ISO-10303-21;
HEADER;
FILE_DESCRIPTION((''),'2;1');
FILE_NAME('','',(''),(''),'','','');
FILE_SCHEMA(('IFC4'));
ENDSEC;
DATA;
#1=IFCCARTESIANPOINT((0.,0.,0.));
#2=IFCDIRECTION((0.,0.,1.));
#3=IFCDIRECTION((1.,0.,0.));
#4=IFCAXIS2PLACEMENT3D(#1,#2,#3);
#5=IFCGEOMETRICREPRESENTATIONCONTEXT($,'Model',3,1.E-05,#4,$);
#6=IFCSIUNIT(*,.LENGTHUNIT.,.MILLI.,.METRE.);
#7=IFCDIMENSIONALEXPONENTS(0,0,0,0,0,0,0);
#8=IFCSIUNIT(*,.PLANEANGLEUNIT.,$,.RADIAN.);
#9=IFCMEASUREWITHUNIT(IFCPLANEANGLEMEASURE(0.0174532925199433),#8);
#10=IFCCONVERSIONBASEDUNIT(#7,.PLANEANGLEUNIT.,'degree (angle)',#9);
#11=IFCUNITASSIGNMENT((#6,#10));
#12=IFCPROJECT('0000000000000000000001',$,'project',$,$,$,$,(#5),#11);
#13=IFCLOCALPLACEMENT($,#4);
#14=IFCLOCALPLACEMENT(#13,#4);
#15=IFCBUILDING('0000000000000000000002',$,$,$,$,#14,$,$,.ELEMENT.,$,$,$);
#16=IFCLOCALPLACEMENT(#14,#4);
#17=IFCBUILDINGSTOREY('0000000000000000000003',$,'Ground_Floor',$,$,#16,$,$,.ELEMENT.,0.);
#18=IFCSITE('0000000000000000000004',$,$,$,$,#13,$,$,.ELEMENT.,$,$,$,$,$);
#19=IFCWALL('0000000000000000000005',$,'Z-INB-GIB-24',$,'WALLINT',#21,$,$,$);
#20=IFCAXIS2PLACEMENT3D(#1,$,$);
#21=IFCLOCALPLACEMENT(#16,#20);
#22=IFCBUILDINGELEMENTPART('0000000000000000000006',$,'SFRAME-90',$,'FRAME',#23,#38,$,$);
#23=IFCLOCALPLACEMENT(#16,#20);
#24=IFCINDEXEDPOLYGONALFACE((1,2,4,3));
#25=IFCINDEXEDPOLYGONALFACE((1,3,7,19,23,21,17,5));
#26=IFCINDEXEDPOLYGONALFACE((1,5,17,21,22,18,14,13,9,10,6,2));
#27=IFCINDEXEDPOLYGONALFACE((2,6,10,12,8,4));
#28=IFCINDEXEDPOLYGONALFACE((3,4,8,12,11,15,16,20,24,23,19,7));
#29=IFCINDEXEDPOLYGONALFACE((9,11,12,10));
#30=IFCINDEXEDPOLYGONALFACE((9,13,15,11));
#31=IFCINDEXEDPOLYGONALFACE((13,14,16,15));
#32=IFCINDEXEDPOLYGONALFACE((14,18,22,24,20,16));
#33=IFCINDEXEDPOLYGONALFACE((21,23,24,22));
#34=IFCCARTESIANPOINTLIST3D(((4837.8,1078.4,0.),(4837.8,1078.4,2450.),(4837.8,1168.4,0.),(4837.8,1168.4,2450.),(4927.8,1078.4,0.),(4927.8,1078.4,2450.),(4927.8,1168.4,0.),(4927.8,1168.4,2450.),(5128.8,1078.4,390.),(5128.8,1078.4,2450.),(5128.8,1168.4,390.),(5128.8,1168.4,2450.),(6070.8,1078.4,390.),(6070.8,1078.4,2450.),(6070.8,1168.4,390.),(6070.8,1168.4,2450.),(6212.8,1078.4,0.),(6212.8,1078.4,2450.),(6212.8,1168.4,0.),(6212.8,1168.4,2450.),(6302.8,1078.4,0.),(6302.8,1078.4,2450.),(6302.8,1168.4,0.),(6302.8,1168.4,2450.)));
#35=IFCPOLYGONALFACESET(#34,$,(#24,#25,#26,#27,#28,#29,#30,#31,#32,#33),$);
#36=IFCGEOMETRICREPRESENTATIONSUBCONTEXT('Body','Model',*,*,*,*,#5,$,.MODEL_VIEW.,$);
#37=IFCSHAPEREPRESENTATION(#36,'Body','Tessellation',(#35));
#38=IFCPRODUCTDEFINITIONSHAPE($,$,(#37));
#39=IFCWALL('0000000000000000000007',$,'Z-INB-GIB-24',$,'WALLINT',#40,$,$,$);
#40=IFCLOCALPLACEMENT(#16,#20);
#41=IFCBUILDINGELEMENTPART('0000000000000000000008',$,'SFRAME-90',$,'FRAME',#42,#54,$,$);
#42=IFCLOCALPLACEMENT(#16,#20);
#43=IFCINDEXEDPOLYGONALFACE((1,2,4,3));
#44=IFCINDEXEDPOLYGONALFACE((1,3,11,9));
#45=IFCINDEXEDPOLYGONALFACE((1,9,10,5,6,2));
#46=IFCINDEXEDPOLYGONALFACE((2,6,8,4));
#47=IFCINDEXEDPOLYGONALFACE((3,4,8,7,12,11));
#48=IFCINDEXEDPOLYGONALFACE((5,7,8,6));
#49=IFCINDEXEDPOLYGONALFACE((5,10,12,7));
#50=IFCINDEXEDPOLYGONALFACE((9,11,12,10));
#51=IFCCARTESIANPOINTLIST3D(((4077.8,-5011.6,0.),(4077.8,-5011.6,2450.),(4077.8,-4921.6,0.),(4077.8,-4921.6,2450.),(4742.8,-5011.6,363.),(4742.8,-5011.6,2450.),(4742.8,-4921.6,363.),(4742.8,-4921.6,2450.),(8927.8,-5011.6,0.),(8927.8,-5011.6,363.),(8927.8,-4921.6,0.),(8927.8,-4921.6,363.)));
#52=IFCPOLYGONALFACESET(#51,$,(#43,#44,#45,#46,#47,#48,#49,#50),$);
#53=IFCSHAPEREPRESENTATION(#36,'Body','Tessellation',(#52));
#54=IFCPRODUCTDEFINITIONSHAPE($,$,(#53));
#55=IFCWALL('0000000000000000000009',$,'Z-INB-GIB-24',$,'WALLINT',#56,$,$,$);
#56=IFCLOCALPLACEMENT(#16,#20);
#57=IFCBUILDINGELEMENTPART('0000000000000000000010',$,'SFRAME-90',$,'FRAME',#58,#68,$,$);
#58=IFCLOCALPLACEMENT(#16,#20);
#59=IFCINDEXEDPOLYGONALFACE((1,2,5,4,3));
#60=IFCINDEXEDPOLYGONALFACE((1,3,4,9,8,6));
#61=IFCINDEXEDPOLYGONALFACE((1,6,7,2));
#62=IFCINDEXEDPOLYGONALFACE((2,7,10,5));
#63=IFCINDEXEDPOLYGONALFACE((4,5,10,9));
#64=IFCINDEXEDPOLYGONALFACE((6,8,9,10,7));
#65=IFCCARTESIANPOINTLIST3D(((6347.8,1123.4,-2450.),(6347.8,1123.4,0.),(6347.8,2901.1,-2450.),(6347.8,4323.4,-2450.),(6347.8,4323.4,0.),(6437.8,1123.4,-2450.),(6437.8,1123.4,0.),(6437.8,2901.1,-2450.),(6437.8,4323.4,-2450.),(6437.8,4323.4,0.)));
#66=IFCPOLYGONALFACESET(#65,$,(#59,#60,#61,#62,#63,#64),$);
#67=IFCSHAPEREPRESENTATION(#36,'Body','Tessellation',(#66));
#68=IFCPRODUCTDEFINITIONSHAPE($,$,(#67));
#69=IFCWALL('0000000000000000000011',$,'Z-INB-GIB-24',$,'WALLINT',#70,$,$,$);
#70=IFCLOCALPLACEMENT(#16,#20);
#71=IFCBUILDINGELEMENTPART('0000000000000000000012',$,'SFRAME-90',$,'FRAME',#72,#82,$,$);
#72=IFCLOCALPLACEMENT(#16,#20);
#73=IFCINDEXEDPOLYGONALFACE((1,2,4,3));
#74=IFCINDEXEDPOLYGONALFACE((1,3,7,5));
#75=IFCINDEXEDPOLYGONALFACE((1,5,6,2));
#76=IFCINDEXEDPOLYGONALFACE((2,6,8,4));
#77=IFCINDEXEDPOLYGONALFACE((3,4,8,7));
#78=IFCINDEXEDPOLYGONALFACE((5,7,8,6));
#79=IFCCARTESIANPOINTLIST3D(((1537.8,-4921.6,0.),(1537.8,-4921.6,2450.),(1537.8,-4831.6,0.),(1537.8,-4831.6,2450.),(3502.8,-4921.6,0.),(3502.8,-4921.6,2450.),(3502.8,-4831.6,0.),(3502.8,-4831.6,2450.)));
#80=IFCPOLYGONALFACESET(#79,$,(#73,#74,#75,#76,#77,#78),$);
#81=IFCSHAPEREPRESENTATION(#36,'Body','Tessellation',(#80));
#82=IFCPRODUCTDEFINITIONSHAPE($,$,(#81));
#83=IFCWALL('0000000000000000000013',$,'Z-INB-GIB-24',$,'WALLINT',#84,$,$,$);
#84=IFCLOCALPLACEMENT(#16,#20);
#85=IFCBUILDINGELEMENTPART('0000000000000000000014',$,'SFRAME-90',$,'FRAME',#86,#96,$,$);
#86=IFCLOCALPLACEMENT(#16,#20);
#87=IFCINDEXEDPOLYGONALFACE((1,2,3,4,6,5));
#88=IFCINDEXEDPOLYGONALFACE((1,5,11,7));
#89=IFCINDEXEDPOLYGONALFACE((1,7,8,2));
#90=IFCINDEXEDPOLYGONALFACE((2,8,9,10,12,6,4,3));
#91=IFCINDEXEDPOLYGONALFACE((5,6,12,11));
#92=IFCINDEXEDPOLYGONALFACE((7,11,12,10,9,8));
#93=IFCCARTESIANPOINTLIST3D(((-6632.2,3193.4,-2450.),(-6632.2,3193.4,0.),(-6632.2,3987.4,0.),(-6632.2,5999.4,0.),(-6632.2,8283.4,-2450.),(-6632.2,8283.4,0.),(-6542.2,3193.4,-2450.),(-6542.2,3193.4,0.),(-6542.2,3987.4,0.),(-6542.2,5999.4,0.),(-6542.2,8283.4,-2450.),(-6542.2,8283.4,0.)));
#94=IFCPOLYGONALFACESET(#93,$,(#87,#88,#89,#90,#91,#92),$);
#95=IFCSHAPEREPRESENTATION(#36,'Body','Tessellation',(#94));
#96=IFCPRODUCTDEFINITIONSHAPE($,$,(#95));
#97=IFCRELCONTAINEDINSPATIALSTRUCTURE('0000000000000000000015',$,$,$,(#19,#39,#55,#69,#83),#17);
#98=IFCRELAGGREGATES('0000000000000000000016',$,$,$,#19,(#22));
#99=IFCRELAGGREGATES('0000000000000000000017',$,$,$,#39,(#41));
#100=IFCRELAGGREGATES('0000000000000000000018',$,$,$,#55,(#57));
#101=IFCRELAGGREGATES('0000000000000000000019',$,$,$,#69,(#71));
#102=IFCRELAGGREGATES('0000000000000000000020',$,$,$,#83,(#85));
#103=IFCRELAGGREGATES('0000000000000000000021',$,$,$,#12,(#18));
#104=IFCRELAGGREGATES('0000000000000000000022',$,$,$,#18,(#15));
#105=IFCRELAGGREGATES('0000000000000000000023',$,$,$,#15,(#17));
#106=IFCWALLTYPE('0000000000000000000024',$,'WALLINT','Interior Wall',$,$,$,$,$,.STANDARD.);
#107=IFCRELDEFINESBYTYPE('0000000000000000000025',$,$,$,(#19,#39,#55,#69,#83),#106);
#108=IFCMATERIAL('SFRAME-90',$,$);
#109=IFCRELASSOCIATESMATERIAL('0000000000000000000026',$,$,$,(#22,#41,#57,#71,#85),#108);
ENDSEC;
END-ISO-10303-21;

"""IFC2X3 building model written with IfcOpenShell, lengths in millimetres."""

from ifc_helpers import new_model, entity, si_unit, converted_unit, frame, origin_with_axes, place, context, subcontext, project, spatial, polyline, segment, composite_curve, outline, extrude, material, type_object, element, aggregate, save


model = new_model("IFC2X3")

# Units and contexts
model_context = context("Model", 3, precision=1e-05, world=origin_with_axes())
body_context = subcontext(model_context, "Body", "Model", "MODEL_VIEW")
ifc_project = project(units=[si_unit("LENGTHUNIT", "METRE", prefix="MILLI"), converted_unit("PLANEANGLEUNIT", "degree (angle)", entity("IfcPlaneAngleMeasure", 0.0174532925199433), si_unit("PLANEANGLEUNIT", "RADIAN"), dimensions=[0, 0, 0, 0, 0, 0, 0])], contexts=[model_context])

# Site, building, storey
site_placement = place(None, origin_with_axes())
site = spatial("IfcSite", under=ifc_project, at=site_placement, CompositionType="ELEMENT")
building_placement = place(site_placement, origin_with_axes())
building = spatial("IfcBuilding", under=site, at=building_placement, CompositionType="ELEMENT")
storey_placement = place(building_placement, origin_with_axes())
storey = spatial("IfcBuildingStorey", under=building, at=storey_placement, Name="Ground_Floor", CompositionType="ELEMENT", Elevation=0.0)

# Walls, building element parts
wall_type = type_object("IfcWallType", Name="WALLINT", Description="Interior Wall", PredefinedType="STANDARD")
ifc_material = material(Name="SFRAME-90")
wall_1_placement = place(storey_placement, frame((6302.8, 1123.4, 2450.0), z_axis=(0.0, 0.0, 1.0), x_axis=(-1.0, 0.0, 0.0)))
wall_1 = element("IfcWall", 1, at=wall_1_placement, inside=storey, type_object=wall_type, Name="Z-INB-GIB-24", ObjectType="WALLINT")
building_element_part_1_placement = place(wall_1_placement, origin_with_axes())
building_element_part_1 = element("IfcBuildingElementPart", 2, at=building_element_part_1_placement, material=ifc_material, Name="SFRAME-90", ObjectType="FRAME", context=body_context, shape_type="SweptSolid", body=[
    extrude(outline(composite_curve([segment(polyline([(0.0, 0.0), (90.0, 0.0), (232.0, 0.0), (232.0, 2060.0), (1174.0, 2060.0), (1174.0, 0.0), (1375.0, 0.0), (1465.0, 0.0), (1465.0, 2450.0), (1375.0, 2450.0), (90.0, 2450.0), (0.0, 2450.0), (0.0, 0.0)]), True, "CONTINUOUS")], self_intersect=False)), frame((0.0, -45.0, 0.0), z_axis=(0.0, 1.0, 0.0), x_axis=(1.0, 0.0, 0.0)), (0.0, 0.0, 1.0), 90.0),
])
aggregate(wall_1, [building_element_part_1])
wall_2_placement = place(storey_placement, frame((9592.8, -4966.6, 2450.0), z_axis=(0.0, 0.0, 1.0), x_axis=(-1.0, 0.0, 0.0)))
wall_2 = element("IfcWall", 3, at=wall_2_placement, inside=storey, type_object=wall_type, Name="Z-INB-GIB-24", ObjectType="WALLINT")
building_element_part_2_placement = place(wall_2_placement, origin_with_axes())
building_element_part_2 = element("IfcBuildingElementPart", 4, at=building_element_part_2_placement, material=ifc_material, Name="SFRAME-90", ObjectType="FRAME", context=body_context, shape_type="SweptSolid", body=[
    extrude(outline(composite_curve([segment(polyline([(0.0, 0.0), (0.0, 2087.0), (4850.0, 2087.0), (4850.0, 0.0), (5515.0, 0.0), (5515.0, 2450.0), (665.0, 2450.0), (665.0, 0.0), (0.0, 0.0)]), True, "CONTINUOUS")], self_intersect=False)), frame((0.0, -45.0, 0.0), z_axis=(0.0, 1.0, 0.0), x_axis=(1.0, 0.0, 0.0)), (0.0, 0.0, 1.0), 90.0),
])
aggregate(wall_2, [building_element_part_2])
wall_3_placement = place(storey_placement, frame((6392.8, 1123.4, 0.0), z_axis=(0.0, 0.0, 1.0), x_axis=(0.0, 1.0, 0.0)))
wall_3 = element("IfcWall", 5, at=wall_3_placement, inside=storey, type_object=wall_type, Name="Z-INB-GIB-24", ObjectType="WALLINT")
building_element_part_3_placement = place(wall_3_placement, origin_with_axes())
building_element_part_3 = element("IfcBuildingElementPart", 6, at=building_element_part_3_placement, material=ifc_material, Name="SFRAME-90", ObjectType="FRAME", context=body_context, shape_type="SweptSolid", body=[
    extrude(outline(composite_curve([segment(polyline([(0.0, 2450.0), (0.0, 0.0), (3200.0, 0.0), (3200.0, 2450.0), (1777.8, 2450.0), (0.0, 2450.0)]), True, "CONTINUOUS")], self_intersect=False)), frame((0.0, -45.0, 0.0), z_axis=(0.0, 1.0, 0.0), x_axis=(1.0, 0.0, 0.0)), (0.0, 0.0, 1.0), 90.0),
])
aggregate(wall_3, [building_element_part_3])
wall_4_placement = place(storey_placement, frame((3502.8, -4876.6, 2450.0), z_axis=(0.0, 0.0, 1.0), x_axis=(-1.0, 0.0, 0.0)))
wall_4 = element("IfcWall", 7, at=wall_4_placement, inside=storey, type_object=wall_type, Name="Z-INB-GIB-24", ObjectType="WALLINT")
building_element_part_4_placement = place(wall_4_placement, origin_with_axes())
building_element_part_4 = element("IfcBuildingElementPart", 8, at=building_element_part_4_placement, material=ifc_material, Name="SFRAME-90", ObjectType="FRAME", context=body_context, shape_type="SweptSolid", body=[
    extrude(outline(composite_curve([segment(polyline([(0.0, 2450.0), (1965.0, 2450.0), (1965.0, 0.0), (0.0, 0.0), (0.0, 2450.0)]), True, "CONTINUOUS")], self_intersect=False)), frame((0.0, -45.0, 0.0), z_axis=(0.0, 1.0, 0.0), x_axis=(1.0, 0.0, 0.0)), (0.0, 0.0, 1.0), 90.0),
])
aggregate(wall_4, [building_element_part_4])
wall_5_placement = place(storey_placement, frame((-6587.2, 3193.4, 0.0), z_axis=(0.0, 0.0, 1.0), x_axis=(0.0, 1.0, 0.0)))
wall_5 = element("IfcWall", 9, at=wall_5_placement, inside=storey, type_object=wall_type, Name="Z-INB-GIB-24", ObjectType="WALLINT")
building_element_part_5_placement = place(wall_5_placement, origin_with_axes())
building_element_part_5 = element("IfcBuildingElementPart", 10, at=building_element_part_5_placement, material=ifc_material, Name="SFRAME-90", ObjectType="FRAME", context=body_context, shape_type="SweptSolid", body=[
    extrude(outline(composite_curve([segment(polyline([(0.0, 0.0), (0.0, 2450.0), (5090.0, 2450.0), (5090.0, 0.0), (2806.0, 0.0), (794.0, 0.0), (0.0, 0.0)]), True, "CONTINUOUS")], self_intersect=False)), frame((0.0, -45.0, 0.0), z_axis=(0.0, 1.0, 0.0), x_axis=(1.0, 0.0, 0.0)), (0.0, 0.0, 1.0), 90.0),
])
aggregate(wall_5, [building_element_part_5])

save(model, "model.ifc")
